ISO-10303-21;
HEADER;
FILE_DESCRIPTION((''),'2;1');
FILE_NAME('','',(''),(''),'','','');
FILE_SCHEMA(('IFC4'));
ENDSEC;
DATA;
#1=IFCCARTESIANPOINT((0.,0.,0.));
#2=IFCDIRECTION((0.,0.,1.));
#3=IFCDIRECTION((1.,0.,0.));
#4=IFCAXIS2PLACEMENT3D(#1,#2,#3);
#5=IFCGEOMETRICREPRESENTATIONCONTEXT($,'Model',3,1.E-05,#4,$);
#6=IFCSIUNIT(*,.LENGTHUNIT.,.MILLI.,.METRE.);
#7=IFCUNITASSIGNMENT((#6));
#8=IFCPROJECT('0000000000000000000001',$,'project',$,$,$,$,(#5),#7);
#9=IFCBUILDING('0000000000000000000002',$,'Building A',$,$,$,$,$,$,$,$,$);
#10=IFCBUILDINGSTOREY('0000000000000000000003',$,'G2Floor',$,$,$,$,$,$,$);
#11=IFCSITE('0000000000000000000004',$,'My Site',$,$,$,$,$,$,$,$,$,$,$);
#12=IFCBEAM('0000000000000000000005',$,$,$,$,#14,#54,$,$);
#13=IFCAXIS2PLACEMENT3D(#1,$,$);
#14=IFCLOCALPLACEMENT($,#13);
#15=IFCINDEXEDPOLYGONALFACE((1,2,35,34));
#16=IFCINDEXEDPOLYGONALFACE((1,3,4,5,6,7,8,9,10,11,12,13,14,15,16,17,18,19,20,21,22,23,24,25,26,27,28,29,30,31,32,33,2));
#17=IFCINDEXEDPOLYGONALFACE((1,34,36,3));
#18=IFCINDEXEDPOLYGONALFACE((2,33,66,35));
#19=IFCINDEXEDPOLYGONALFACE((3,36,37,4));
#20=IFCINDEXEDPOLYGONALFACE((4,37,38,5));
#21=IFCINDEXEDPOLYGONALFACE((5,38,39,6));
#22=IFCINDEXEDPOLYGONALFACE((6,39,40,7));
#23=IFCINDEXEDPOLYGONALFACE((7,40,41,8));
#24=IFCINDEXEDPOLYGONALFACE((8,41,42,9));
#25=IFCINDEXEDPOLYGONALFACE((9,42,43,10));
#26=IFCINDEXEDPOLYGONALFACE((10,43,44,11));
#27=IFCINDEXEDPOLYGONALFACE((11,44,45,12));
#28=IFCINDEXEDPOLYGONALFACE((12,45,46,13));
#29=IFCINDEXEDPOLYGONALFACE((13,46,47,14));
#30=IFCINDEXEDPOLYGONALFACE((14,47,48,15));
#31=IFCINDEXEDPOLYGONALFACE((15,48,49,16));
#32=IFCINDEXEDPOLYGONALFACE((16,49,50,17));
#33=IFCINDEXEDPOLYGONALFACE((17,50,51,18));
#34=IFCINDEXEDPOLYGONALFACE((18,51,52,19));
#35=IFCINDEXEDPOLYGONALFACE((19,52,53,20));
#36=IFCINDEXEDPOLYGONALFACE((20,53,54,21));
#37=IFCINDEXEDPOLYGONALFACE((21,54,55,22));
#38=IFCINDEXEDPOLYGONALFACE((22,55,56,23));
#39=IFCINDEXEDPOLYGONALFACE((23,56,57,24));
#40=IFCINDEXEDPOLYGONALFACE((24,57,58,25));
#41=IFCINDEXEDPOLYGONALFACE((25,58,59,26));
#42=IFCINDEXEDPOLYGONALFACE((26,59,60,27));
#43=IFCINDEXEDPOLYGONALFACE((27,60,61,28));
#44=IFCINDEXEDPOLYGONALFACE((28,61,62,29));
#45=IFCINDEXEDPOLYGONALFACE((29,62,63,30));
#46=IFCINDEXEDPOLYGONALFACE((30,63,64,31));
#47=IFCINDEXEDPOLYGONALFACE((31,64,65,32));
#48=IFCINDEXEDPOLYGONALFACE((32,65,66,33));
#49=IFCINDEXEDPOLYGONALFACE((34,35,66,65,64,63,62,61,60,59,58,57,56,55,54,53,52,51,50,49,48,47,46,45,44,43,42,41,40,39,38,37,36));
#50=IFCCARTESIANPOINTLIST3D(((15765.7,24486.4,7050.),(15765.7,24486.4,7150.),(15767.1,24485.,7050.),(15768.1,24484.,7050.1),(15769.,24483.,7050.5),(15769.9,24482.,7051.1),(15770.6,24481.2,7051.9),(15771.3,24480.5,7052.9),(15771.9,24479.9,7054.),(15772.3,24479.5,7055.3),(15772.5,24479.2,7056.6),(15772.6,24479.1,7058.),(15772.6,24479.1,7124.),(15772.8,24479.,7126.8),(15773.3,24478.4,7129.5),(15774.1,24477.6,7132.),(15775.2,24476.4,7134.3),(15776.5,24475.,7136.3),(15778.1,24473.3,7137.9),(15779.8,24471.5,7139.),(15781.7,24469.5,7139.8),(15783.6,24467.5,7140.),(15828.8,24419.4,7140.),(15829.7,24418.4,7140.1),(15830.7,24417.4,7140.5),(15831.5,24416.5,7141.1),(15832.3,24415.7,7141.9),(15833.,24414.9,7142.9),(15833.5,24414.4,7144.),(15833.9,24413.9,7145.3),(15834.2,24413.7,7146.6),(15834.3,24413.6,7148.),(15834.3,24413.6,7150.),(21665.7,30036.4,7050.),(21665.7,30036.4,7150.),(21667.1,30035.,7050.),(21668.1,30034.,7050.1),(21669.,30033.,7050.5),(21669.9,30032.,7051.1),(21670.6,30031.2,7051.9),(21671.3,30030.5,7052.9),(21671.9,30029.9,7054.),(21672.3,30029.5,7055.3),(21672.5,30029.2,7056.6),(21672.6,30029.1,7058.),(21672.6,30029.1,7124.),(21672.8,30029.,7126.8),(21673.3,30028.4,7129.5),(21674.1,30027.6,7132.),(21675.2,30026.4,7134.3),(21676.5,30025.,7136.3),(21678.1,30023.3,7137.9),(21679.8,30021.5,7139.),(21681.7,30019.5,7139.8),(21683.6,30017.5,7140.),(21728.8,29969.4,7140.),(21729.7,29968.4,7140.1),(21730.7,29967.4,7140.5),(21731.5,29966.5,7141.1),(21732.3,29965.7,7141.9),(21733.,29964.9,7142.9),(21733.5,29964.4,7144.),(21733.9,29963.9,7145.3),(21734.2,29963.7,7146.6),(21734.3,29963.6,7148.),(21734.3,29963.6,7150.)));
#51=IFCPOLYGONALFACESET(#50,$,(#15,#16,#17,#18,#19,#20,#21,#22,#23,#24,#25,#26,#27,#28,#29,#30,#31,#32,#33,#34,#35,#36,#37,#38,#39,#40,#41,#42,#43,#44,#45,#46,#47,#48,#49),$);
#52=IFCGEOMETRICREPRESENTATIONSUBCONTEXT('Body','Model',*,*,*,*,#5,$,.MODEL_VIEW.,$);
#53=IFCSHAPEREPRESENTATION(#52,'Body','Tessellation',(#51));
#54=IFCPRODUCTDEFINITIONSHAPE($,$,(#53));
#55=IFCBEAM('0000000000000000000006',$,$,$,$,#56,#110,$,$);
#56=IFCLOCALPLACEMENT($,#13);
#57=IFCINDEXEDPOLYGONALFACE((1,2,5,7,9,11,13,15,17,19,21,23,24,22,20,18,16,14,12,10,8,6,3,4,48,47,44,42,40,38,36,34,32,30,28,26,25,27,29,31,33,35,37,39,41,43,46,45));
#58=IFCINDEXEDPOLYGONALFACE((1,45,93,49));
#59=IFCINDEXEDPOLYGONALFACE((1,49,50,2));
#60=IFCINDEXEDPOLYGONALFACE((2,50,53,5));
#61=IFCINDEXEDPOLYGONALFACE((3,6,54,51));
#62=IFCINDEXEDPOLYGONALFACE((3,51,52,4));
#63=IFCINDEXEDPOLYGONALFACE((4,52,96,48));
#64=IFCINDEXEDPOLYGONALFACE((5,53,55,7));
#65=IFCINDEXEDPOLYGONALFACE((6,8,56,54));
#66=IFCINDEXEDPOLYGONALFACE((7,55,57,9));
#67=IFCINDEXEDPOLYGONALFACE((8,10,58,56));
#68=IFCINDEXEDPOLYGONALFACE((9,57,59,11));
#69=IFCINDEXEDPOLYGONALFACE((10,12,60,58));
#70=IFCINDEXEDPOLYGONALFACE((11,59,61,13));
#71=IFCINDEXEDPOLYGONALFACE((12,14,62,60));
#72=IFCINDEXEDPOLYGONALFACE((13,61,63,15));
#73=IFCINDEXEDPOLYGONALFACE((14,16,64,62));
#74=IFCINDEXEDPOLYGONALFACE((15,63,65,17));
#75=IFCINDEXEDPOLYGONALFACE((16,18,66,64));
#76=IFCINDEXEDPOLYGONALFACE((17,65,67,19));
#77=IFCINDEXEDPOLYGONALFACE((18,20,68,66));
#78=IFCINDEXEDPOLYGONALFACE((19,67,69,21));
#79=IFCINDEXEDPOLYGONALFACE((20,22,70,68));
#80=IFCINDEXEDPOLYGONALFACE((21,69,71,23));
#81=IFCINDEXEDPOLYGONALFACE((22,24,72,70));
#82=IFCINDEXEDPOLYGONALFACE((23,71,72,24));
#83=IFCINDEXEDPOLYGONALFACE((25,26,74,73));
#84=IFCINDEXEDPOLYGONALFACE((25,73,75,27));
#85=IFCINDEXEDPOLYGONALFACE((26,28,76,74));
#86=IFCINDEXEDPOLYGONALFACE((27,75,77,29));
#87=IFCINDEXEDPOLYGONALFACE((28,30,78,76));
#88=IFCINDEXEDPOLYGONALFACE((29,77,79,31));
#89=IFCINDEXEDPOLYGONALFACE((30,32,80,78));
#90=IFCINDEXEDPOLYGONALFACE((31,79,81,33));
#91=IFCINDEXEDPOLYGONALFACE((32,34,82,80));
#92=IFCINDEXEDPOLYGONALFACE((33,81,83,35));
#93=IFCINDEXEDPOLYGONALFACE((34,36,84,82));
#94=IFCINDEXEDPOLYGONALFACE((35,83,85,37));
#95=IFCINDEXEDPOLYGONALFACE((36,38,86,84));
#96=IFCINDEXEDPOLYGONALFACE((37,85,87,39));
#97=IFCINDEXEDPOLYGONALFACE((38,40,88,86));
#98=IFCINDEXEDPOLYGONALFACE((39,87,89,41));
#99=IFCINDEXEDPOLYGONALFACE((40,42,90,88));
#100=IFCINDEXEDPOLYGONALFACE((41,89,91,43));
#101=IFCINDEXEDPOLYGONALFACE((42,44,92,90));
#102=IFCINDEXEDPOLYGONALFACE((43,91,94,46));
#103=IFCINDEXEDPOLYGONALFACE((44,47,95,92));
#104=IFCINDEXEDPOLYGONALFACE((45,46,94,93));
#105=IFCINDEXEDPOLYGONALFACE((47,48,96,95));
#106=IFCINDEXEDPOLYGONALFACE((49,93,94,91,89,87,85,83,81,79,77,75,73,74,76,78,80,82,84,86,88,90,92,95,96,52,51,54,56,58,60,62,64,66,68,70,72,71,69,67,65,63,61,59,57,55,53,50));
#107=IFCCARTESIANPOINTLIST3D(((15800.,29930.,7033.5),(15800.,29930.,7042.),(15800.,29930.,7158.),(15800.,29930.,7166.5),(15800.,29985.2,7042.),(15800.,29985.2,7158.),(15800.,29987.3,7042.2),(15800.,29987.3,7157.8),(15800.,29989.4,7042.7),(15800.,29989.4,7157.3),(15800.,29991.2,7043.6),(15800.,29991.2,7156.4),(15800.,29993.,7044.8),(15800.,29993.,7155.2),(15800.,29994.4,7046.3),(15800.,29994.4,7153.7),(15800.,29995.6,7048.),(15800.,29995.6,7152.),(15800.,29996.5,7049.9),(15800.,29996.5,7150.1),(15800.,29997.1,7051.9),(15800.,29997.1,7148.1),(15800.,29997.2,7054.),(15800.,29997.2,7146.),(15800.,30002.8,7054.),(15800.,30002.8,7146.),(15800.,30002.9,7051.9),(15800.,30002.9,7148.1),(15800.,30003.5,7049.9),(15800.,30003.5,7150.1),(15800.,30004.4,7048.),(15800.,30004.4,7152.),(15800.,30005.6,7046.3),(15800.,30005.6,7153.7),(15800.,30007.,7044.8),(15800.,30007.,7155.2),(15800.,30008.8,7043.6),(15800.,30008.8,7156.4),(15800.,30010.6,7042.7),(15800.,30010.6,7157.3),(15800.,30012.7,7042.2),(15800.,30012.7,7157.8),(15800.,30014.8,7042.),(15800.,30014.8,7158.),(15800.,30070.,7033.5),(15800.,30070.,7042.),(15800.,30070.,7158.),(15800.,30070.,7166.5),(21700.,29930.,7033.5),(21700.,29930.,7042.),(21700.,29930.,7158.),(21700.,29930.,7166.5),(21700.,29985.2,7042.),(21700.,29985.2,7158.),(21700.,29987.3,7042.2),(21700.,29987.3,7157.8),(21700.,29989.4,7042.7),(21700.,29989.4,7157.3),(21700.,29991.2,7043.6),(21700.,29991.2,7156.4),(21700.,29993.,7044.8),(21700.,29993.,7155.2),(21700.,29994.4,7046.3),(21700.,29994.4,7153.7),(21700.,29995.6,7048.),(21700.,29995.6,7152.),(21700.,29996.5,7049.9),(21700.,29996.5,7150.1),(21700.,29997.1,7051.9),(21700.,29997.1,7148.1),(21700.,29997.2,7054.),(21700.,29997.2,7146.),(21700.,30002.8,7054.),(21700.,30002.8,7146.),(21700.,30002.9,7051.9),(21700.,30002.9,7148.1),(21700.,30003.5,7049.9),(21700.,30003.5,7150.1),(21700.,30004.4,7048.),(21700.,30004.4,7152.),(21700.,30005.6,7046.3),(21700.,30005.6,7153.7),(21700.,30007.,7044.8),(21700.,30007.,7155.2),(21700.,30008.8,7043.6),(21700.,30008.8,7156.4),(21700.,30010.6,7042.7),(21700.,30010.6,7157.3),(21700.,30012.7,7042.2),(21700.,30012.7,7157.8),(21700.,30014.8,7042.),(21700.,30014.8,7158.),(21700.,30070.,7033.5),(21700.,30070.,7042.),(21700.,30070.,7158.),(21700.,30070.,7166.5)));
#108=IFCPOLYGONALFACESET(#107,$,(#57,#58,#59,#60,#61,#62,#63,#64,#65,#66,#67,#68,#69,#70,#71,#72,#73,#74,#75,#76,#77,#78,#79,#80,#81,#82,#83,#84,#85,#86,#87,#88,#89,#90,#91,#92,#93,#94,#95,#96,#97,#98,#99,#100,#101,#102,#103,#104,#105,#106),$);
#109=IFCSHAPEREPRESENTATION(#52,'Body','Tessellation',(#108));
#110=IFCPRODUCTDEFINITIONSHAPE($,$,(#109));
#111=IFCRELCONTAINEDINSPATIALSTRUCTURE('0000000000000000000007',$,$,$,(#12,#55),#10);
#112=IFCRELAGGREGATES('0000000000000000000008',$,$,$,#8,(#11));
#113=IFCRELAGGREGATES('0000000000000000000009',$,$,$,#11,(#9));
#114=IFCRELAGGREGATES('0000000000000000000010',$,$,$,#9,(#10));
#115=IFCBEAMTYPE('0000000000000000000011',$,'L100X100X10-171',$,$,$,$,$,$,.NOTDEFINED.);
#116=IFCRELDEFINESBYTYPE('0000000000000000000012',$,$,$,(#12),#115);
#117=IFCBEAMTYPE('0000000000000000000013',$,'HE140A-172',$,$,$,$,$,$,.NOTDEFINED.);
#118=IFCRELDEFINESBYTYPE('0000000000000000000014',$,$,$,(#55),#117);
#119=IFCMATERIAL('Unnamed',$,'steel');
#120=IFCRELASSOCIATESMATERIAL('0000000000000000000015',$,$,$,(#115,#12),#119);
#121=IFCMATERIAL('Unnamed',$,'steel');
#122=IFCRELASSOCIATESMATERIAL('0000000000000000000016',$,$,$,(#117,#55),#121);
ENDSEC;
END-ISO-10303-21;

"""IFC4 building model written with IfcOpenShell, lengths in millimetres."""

from ifc_helpers import new_model, si_unit, frame, origin_with_axes, place, context, subcontext, project, spatial, polyline, outline, extrude, material, material_profile, profile_set, profile_usage, type_object, element, save


model = new_model("IFC4")

# Units and contexts
model_context = context("Model", 3, precision=1e-05, world=origin_with_axes())
body_context = subcontext(model_context, "Body", "Model", "MODEL_VIEW")
ifc_project = project(units=[si_unit("LENGTHUNIT", "METRE", prefix="MILLI")], contexts=[model_context])

# Site, building, storey
site = spatial("IfcSite", under=ifc_project, Name="My Site")
building = spatial("IfcBuilding", under=site, Name="Building A")
storey = spatial("IfcBuildingStorey", under=building, Name="G2Floor")

# Beams
ifc_material_1 = material(Name="Unnamed", Category="steel")
ifc_material_profile_1 = material_profile(ifc_material_1, outline(polyline([(-50.0, -50.0), (50.0, -50.0), (50.0, -50.0), (50.0, -48.0), (50.0, -48.0), (49.9, -46.6), (49.9, -46.6), (49.5, -45.3), (49.5, -45.3), (48.9, -44.0), (48.9, -44.0), (48.1, -42.9), (48.1, -42.9), (47.1, -41.9), (47.1, -41.9), (46.0, -41.1), (46.0, -41.1), (44.7, -40.5), (44.7, -40.5), (43.4, -40.1), (43.4, -40.1), (42.0, -40.0), (42.0, -40.0), (-24.0, -40.0), (-24.0, -40.0), (-26.8, -39.8), (-26.8, -39.8), (-29.5, -39.0), (-29.5, -39.0), (-32.0, -37.9), (-32.0, -37.9), (-34.3, -36.3), (-34.3, -36.3), (-36.3, -34.3), (-36.3, -34.3), (-37.9, -32.0), (-37.9, -32.0), (-39.0, -29.5), (-39.0, -29.5), (-39.8, -26.8), (-39.8, -26.8), (-40.0, -24.0), (-40.0, -24.0), (-40.0, 42.0), (-40.0, 42.0), (-40.1, 43.4), (-40.1, 43.4), (-40.5, 44.7), (-40.5, 44.7), (-41.1, 46.0), (-41.1, 46.0), (-41.9, 47.1), (-41.9, 47.1), (-42.9, 48.1), (-42.9, 48.1), (-44.0, 48.9), (-44.0, 48.9), (-45.3, 49.5), (-45.3, 49.5), (-46.6, 49.9), (-46.6, 49.9), (-48.0, 50.0), (-48.0, 50.0), (-50.0, 50.0), (-50.0, 50.0), (-50.0, -50.0)])))
ifc_profile_set_1 = profile_set([ifc_material_profile_1], Name="L100X100X10-171")
ifc_profile_usage_1 = profile_usage(ifc_profile_set_1)
beam_type_1 = type_object("IfcBeamType", Name="L100X100X10-171", PredefinedType="NOTDEFINED", material=ifc_profile_set_1)
beam_1_placement = place(None, frame((15800.0, 24450.0, 7100.0), z_axis=(0.728381, 0.685172, 0.0), x_axis=(0.685172, -0.728381, 0.0)))
element("IfcBeam", 1, at=beam_1_placement, inside=storey, type_object=beam_type_1, material=ifc_profile_usage_1, context=body_context, shape_type="SweptSolid", body=[
    extrude(outline(polyline([(-50.0, -50.0), (50.0, -50.0), (50.0, -50.0), (50.0, -48.0), (50.0, -48.0), (49.9, -46.6), (49.9, -46.6), (49.5, -45.3), (49.5, -45.3), (48.9, -44.0), (48.9, -44.0), (48.1, -42.9), (48.1, -42.9), (47.1, -41.9), (47.1, -41.9), (46.0, -41.1), (46.0, -41.1), (44.7, -40.5), (44.7, -40.5), (43.4, -40.1), (43.4, -40.1), (42.0, -40.0), (42.0, -40.0), (-24.0, -40.0), (-24.0, -40.0), (-26.8, -39.8), (-26.8, -39.8), (-29.5, -39.0), (-29.5, -39.0), (-32.0, -37.9), (-32.0, -37.9), (-34.3, -36.3), (-34.3, -36.3), (-36.3, -34.3), (-36.3, -34.3), (-37.9, -32.0), (-37.9, -32.0), (-39.0, -29.5), (-39.0, -29.5), (-39.8, -26.8), (-39.8, -26.8), (-40.0, -24.0), (-40.0, -24.0), (-40.0, 42.0), (-40.0, 42.0), (-40.1, 43.4), (-40.1, 43.4), (-40.5, 44.7), (-40.5, 44.7), (-41.1, 46.0), (-41.1, 46.0), (-41.9, 47.1), (-41.9, 47.1), (-42.9, 48.1), (-42.9, 48.1), (-44.0, 48.9), (-44.0, 48.9), (-45.3, 49.5), (-45.3, 49.5), (-46.6, 49.9), (-46.6, 49.9), (-48.0, 50.0), (-48.0, 50.0), (-50.0, 50.0), (-50.0, 50.0), (-50.0, -50.0)])), origin_with_axes(), (0.0, 0.0, 1.0), 8100.2),
])
ifc_material_2 = material(Name="Unnamed", Category="steel")
ifc_material_profile_2 = material_profile(ifc_material_2, outline(polyline([(70.0, -66.5), (70.0, -58.0), (70.0, -58.0), (14.8, -58.0), (14.8, -58.0), (12.7, -57.8), (12.7, -57.8), (10.6, -57.3), (10.6, -57.3), (8.8, -56.4), (8.8, -56.4), (7.0, -55.2), (7.0, -55.2), (5.6, -53.7), (5.6, -53.7), (4.4, -52.0), (4.4, -52.0), (3.5, -50.1), (3.5, -50.1), (2.9, -48.1), (2.9, -48.1), (2.8, -46.0), (2.8, -46.0), (2.8, 46.0), (2.8, 46.0), (2.9, 48.1), (2.9, 48.1), (3.5, 50.1), (3.5, 50.1), (4.4, 52.0), (4.4, 52.0), (5.6, 53.7), (5.6, 53.7), (7.0, 55.2), (7.0, 55.2), (8.8, 56.4), (8.8, 56.4), (10.6, 57.3), (10.6, 57.3), (12.7, 57.8), (12.7, 57.8), (14.8, 58.0), (14.8, 58.0), (70.0, 58.0), (70.0, 58.0), (70.0, 66.5), (70.0, 66.5), (-70.0, 66.5), (-70.0, 66.5), (-70.0, 58.0), (-70.0, 58.0), (-14.8, 58.0), (-14.8, 58.0), (-12.7, 57.8), (-12.7, 57.8), (-10.6, 57.3), (-10.6, 57.3), (-8.8, 56.4), (-8.8, 56.4), (-7.0, 55.2), (-7.0, 55.2), (-5.6, 53.7), (-5.6, 53.7), (-4.4, 52.0), (-4.4, 52.0), (-3.5, 50.1), (-3.5, 50.1), (-2.9, 48.1), (-2.9, 48.1), (-2.8, 46.0), (-2.8, 46.0), (-2.8, -46.0), (-2.8, -46.0), (-2.9, -48.1), (-2.9, -48.1), (-3.5, -50.1), (-3.5, -50.1), (-4.4, -52.0), (-4.4, -52.0), (-5.6, -53.7), (-5.6, -53.7), (-7.0, -55.2), (-7.0, -55.2), (-8.8, -56.4), (-8.8, -56.4), (-10.6, -57.3), (-10.6, -57.3), (-12.7, -57.8), (-12.7, -57.8), (-14.8, -58.0), (-14.8, -58.0), (-70.0, -58.0), (-70.0, -58.0), (-70.0, -66.5), (-70.0, -66.5), (70.0, -66.5)])))
ifc_profile_set_2 = profile_set([ifc_material_profile_2], Name="HE140A-172")
ifc_profile_usage_2 = profile_usage(ifc_profile_set_2)
beam_type_2 = type_object("IfcBeamType", Name="HE140A-172", PredefinedType="NOTDEFINED", material=ifc_profile_set_2)
beam_2_placement = place(None, frame((15800.0, 30000.0, 7100.0), z_axis=(1.0, 0.0, 0.0), x_axis=(0.0, -1.0, 0.0)))
element("IfcBeam", 2, at=beam_2_placement, inside=storey, type_object=beam_type_2, material=ifc_profile_usage_2, context=body_context, shape_type="SweptSolid", body=[
    extrude(outline(polyline([(70.0, -66.5), (70.0, -58.0), (70.0, -58.0), (14.8, -58.0), (14.8, -58.0), (12.7, -57.8), (12.7, -57.8), (10.6, -57.3), (10.6, -57.3), (8.8, -56.4), (8.8, -56.4), (7.0, -55.2), (7.0, -55.2), (5.6, -53.7), (5.6, -53.7), (4.4, -52.0), (4.4, -52.0), (3.5, -50.1), (3.5, -50.1), (2.9, -48.1), (2.9, -48.1), (2.8, -46.0), (2.8, -46.0), (2.8, 46.0), (2.8, 46.0), (2.9, 48.1), (2.9, 48.1), (3.5, 50.1), (3.5, 50.1), (4.4, 52.0), (4.4, 52.0), (5.6, 53.7), (5.6, 53.7), (7.0, 55.2), (7.0, 55.2), (8.8, 56.4), (8.8, 56.4), (10.6, 57.3), (10.6, 57.3), (12.7, 57.8), (12.7, 57.8), (14.8, 58.0), (14.8, 58.0), (70.0, 58.0), (70.0, 58.0), (70.0, 66.5), (70.0, 66.5), (-70.0, 66.5), (-70.0, 66.5), (-70.0, 58.0), (-70.0, 58.0), (-14.8, 58.0), (-14.8, 58.0), (-12.7, 57.8), (-12.7, 57.8), (-10.6, 57.3), (-10.6, 57.3), (-8.8, 56.4), (-8.8, 56.4), (-7.0, 55.2), (-7.0, 55.2), (-5.6, 53.7), (-5.6, 53.7), (-4.4, 52.0), (-4.4, 52.0), (-3.5, 50.1), (-3.5, 50.1), (-2.9, 48.1), (-2.9, 48.1), (-2.8, 46.0), (-2.8, 46.0), (-2.8, -46.0), (-2.8, -46.0), (-2.9, -48.1), (-2.9, -48.1), (-3.5, -50.1), (-3.5, -50.1), (-4.4, -52.0), (-4.4, -52.0), (-5.6, -53.7), (-5.6, -53.7), (-7.0, -55.2), (-7.0, -55.2), (-8.8, -56.4), (-8.8, -56.4), (-10.6, -57.3), (-10.6, -57.3), (-12.7, -57.8), (-12.7, -57.8), (-14.8, -58.0), (-14.8, -58.0), (-70.0, -58.0), (-70.0, -58.0), (-70.0, -66.5), (-70.0, -66.5), (70.0, -66.5)])), origin_with_axes(), (0.0, 0.0, 1.0), 5900.0),
])

save(model, "model.ifc")
